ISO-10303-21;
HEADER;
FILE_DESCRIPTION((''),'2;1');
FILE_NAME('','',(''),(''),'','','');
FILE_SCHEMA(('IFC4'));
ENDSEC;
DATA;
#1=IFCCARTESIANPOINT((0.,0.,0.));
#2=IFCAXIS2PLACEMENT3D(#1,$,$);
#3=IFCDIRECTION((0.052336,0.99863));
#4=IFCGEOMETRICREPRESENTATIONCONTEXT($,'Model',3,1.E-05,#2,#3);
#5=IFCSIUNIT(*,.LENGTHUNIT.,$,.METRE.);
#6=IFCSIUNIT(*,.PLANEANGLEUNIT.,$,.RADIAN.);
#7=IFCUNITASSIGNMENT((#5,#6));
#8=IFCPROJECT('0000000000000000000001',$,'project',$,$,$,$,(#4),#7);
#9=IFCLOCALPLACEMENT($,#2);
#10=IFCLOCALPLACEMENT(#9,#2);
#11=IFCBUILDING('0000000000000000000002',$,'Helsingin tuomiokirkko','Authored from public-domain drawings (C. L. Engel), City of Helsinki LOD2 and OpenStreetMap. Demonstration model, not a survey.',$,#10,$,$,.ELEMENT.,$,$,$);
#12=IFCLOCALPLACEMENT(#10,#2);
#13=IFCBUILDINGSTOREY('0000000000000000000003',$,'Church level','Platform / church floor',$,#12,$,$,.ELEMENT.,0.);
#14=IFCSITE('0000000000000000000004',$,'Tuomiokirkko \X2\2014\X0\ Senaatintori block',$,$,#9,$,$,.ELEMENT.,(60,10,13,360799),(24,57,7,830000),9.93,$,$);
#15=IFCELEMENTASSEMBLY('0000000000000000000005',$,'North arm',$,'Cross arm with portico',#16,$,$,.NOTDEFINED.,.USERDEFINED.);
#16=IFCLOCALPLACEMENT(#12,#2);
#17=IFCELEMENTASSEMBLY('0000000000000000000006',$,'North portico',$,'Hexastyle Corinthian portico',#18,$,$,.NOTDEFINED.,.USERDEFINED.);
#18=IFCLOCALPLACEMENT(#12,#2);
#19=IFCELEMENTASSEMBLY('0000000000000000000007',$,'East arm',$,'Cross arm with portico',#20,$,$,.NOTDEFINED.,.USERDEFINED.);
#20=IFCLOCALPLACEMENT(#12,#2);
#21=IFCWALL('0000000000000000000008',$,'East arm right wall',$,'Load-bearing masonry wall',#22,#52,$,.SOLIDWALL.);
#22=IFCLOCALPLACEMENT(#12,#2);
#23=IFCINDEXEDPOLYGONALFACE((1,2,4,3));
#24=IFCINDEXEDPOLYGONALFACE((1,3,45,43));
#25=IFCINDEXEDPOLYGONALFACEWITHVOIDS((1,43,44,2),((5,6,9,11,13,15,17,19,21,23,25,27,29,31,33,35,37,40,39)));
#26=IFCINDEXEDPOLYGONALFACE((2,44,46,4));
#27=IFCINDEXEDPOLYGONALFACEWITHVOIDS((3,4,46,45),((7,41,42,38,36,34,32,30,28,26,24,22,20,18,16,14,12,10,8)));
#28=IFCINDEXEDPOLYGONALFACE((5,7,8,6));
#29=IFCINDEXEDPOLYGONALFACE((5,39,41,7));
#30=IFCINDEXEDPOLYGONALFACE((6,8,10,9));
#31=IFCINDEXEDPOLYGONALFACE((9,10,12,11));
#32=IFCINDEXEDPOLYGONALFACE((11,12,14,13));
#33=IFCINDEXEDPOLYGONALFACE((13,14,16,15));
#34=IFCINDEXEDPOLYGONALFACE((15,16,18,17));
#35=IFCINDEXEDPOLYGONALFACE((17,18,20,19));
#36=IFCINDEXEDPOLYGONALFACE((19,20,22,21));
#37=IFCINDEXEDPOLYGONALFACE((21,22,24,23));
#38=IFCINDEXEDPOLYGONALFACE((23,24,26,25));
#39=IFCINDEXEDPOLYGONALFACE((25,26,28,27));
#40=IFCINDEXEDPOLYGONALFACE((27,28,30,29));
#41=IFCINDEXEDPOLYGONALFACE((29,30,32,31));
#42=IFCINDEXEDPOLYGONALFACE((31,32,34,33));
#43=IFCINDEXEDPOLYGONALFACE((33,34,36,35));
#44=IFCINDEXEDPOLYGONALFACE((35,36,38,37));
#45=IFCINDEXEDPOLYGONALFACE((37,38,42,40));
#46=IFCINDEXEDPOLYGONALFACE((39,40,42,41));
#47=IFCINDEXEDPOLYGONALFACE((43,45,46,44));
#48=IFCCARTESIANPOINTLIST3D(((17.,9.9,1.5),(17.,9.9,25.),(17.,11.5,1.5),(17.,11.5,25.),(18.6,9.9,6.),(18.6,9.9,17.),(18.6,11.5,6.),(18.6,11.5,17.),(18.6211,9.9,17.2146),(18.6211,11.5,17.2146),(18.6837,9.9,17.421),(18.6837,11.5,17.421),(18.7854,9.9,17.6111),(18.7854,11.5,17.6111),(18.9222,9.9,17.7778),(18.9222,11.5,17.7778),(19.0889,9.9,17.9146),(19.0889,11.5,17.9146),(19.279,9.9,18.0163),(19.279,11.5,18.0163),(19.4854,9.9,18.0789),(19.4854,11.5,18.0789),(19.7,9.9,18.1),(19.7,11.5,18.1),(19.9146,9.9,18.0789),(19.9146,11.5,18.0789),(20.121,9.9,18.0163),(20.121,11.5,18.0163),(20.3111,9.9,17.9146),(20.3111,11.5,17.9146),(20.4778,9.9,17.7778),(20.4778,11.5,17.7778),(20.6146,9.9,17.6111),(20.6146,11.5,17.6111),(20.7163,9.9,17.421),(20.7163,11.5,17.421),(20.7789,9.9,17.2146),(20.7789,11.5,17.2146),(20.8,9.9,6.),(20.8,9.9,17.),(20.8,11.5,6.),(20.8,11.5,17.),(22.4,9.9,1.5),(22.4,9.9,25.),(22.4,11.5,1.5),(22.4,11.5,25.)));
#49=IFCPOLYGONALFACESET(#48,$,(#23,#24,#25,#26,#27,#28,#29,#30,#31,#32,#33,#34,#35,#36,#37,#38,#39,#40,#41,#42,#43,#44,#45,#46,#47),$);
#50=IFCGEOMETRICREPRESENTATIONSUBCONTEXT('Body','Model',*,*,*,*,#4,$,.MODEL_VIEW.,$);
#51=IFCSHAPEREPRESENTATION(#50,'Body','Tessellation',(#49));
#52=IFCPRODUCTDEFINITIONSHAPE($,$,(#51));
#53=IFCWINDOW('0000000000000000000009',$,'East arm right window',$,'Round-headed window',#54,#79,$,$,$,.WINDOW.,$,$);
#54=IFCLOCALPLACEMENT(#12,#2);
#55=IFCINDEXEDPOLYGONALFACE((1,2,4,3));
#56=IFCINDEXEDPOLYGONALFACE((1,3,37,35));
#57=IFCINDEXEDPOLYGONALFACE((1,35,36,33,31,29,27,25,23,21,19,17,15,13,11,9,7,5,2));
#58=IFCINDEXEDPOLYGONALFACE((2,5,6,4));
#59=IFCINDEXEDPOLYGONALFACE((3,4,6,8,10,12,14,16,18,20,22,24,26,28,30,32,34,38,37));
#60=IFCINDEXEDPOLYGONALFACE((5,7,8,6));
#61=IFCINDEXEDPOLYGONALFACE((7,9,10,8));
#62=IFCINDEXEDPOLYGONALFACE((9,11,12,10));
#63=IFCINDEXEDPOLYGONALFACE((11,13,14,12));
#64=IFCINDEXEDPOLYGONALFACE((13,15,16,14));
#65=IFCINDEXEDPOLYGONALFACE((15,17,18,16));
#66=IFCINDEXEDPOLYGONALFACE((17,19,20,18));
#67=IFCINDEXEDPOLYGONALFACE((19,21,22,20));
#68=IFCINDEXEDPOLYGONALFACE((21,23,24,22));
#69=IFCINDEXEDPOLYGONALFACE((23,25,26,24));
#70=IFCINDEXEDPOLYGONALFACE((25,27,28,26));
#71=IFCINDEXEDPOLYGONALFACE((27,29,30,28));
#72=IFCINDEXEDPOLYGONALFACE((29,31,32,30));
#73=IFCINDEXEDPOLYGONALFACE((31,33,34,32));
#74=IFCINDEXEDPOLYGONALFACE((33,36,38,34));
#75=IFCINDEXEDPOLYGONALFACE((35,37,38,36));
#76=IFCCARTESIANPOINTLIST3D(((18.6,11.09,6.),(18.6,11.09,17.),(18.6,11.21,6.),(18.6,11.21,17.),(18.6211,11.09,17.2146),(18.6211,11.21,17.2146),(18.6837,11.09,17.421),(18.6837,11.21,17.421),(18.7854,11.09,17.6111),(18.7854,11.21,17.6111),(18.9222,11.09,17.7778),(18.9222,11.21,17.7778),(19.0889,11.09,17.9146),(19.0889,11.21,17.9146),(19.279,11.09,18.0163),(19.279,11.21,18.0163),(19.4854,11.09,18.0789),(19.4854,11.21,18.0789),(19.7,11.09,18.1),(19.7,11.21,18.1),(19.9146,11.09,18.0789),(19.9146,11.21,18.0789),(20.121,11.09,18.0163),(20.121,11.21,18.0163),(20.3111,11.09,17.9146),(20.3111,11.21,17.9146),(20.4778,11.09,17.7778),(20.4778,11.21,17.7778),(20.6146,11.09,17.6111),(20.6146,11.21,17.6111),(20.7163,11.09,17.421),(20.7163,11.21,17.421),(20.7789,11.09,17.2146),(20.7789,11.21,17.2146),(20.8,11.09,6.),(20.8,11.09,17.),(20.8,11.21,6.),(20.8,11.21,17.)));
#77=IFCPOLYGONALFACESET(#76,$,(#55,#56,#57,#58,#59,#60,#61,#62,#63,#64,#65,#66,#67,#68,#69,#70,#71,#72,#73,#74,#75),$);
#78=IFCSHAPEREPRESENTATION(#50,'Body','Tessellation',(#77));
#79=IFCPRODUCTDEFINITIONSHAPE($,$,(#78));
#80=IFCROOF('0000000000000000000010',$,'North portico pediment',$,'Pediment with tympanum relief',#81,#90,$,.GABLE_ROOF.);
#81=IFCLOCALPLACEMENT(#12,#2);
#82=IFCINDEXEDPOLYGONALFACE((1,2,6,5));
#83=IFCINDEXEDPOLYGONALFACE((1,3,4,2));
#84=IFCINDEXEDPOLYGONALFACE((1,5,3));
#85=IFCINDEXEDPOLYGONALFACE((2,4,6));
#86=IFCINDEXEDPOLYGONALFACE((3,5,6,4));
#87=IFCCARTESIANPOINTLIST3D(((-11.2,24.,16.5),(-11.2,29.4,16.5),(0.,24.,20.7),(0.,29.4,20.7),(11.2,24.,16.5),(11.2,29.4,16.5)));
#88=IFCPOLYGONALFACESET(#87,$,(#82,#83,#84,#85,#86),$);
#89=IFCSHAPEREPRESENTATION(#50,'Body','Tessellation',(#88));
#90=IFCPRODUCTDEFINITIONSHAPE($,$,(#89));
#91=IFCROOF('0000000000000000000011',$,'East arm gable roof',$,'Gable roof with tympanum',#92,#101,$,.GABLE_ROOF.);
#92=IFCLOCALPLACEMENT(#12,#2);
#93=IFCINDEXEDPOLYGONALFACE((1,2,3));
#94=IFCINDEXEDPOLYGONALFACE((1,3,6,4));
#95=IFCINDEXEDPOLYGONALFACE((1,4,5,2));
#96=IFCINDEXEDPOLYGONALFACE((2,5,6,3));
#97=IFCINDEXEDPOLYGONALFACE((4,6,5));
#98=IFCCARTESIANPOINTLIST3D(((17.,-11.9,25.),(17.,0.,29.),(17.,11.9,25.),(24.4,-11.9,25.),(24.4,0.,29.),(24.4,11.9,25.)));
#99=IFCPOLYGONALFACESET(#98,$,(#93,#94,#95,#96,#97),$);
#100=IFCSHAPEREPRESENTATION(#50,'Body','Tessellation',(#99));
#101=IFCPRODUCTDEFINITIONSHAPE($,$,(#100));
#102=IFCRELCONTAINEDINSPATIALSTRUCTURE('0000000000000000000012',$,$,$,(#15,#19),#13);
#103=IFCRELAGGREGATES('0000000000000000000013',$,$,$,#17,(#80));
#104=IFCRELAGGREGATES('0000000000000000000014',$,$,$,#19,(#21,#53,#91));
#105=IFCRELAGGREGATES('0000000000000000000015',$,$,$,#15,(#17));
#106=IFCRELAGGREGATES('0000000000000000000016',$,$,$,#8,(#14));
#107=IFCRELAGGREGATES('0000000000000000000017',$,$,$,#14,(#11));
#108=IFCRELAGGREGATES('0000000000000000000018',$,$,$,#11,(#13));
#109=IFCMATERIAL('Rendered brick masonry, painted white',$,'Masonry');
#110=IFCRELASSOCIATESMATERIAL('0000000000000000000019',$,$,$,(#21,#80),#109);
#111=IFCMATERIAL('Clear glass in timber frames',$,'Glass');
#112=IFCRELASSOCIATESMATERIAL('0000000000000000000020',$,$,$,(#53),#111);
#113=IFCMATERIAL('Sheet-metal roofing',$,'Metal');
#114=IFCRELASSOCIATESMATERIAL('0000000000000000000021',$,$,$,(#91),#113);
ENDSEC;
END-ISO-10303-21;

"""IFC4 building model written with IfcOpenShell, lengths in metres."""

from ifc_helpers import new_model, si_unit, direction, frame, origin, origin_2d_with_axis, place, context, subcontext, project, spatial, polyline, rectangle, outline, extrude, material, element, fill, aggregate, save


model = new_model("IFC4")

# Units and contexts
model_context = context("Model", 3, precision=1e-05, world=origin(), true_north=direction((0.052336, 0.99863)))
body_context = subcontext(model_context, "Body", "Model", "MODEL_VIEW")
ifc_project = project(units=[si_unit("LENGTHUNIT", "METRE"), si_unit("PLANEANGLEUNIT", "RADIAN")], contexts=[model_context])

# Site, building, storey
site_placement = place(None, origin())
site = spatial("IfcSite", under=ifc_project, at=site_placement, Name="Tuomiokirkko — Senaatintori block", CompositionType="ELEMENT", RefLatitude=(60, 10, 13, 360799), RefLongitude=(24, 57, 7, 830000), RefElevation=9.93)
building_placement = place(site_placement, origin())
building = spatial("IfcBuilding", under=site, at=building_placement, Name="Helsingin tuomiokirkko", Description="Authored from public-domain drawings (C. L. Engel), City of Helsinki LOD2 and OpenStreetMap. Demonstration model, not a survey.", CompositionType="ELEMENT")
storey_placement = place(building_placement, origin())
storey = spatial("IfcBuildingStorey", under=building, at=storey_placement, Name="Church level", Description="Platform / church floor", CompositionType="ELEMENT", Elevation=0.0)

# Element assemblies
assembly_1_placement = place(building_placement, origin())
assembly_1 = element("IfcElementAssembly", 1, at=assembly_1_placement, inside=storey, Name="North arm", ObjectType="Cross arm with portico", AssemblyPlace="NOTDEFINED", PredefinedType="USERDEFINED")
assembly_2_placement = place(building_placement, origin())
assembly_2 = element("IfcElementAssembly", 2, at=assembly_2_placement, Name="North portico", ObjectType="Hexastyle Corinthian portico", AssemblyPlace="NOTDEFINED", PredefinedType="USERDEFINED")

# Element assembly
assembly_3_placement = place(building_placement, origin())
assembly_3 = element("IfcElementAssembly", 3, at=assembly_3_placement, inside=storey, Name="East arm", ObjectType="Cross arm with portico", AssemblyPlace="NOTDEFINED", PredefinedType="USERDEFINED")
ifc_material_1 = material(Name="Rendered brick masonry, painted white", Category="Masonry")

# Shared definitions
ifc_material_2 = material(Name="Clear glass in timber frames", Category="Glass")

# Wall, opening, window
wall_1_placement = place(building_placement, origin())
wall_1 = element("IfcWall", 4, at=wall_1_placement, material=ifc_material_1, Name="East arm right wall", ObjectType="Load-bearing masonry wall", PredefinedType="SOLIDWALL", context=body_context, shape_type="SweptSolid", body=[
    extrude(rectangle(XDim=5.4, YDim=1.6, at=origin_2d_with_axis()), frame((19.7, 10.7, 1.5)), (0.0, 0.0, 1.0), 23.5),
])
opening_1_placement = place(building_placement, origin())
opening_1 = element("IfcOpeningElement", 5, at=opening_1_placement, cuts=wall_1, PredefinedType="OPENING", context=body_context, shape_type="SweptSolid", body=[
    extrude(outline(polyline([(-1.1, 0.0), (1.1, 0.0), (1.1, 11.0), (1.0789, 11.2146), (1.0163, 11.421), (0.9146, 11.6111), (0.7778, 11.7778), (0.6111, 11.9146), (0.421, 12.0163), (0.2146, 12.0789), (0.0, 12.1), (-0.2146, 12.0789), (-0.421, 12.0163), (-0.6111, 11.9146), (-0.7778, 11.7778), (-0.9146, 11.6111), (-1.0163, 11.421), (-1.0789, 11.2146), (-1.1, 11.0), (-1.1, 0.0)])), frame((19.7, 11.7, 6.0), z_axis=(0.0, -1.0, 0.0), x_axis=(1.0, 0.0, 0.0)), (0.0, 0.0, 1.0), 2.0),
])
window_1_placement = place(building_placement, origin())
window_1 = element("IfcWindow", 6, at=window_1_placement, material=ifc_material_2, Name="East arm right window", ObjectType="Round-headed window", PredefinedType="WINDOW", context=body_context, shape_type="SweptSolid", body=[
    extrude(outline(polyline([(-1.1, 0.0), (1.1, 0.0), (1.1, 11.0), (1.0789, 11.2146), (1.0163, 11.421), (0.9146, 11.6111), (0.7778, 11.7778), (0.6111, 11.9146), (0.421, 12.0163), (0.2146, 12.0789), (0.0, 12.1), (-0.2146, 12.0789), (-0.421, 12.0163), (-0.6111, 11.9146), (-0.7778, 11.7778), (-0.9146, 11.6111), (-1.0163, 11.421), (-1.0789, 11.2146), (-1.1, 11.0), (-1.1, 0.0)])), frame((19.7, 11.21, 6.0), z_axis=(0.0, -1.0, 0.0), x_axis=(1.0, 0.0, 0.0)), (0.0, 0.0, 1.0), 0.12),
])
fill(opening_1, window_1)

# Roofs
roof_1_placement = place(building_placement, origin())
roof_1 = element("IfcRoof", 7, at=roof_1_placement, material=ifc_material_1, Name="North portico pediment", ObjectType="Pediment with tympanum relief", PredefinedType="GABLE_ROOF", context=body_context, shape_type="SweptSolid", body=[
    extrude(outline(polyline([(-11.2, 0.0), (11.2, 0.0), (0.0, 4.2), (-11.2, 0.0)])), frame((0.0, 24.0, 16.5), z_axis=(0.0, 1.0, 0.0), x_axis=(-1.0, 0.0, 0.0)), (0.0, 0.0, 1.0), 5.4),
])
aggregate(assembly_2, [roof_1])
ifc_material_3 = material(Name="Sheet-metal roofing", Category="Metal")
roof_2_placement = place(building_placement, origin())
roof_2 = element("IfcRoof", 8, at=roof_2_placement, material=ifc_material_3, Name="East arm gable roof", ObjectType="Gable roof with tympanum", PredefinedType="GABLE_ROOF", context=body_context, shape_type="SweptSolid", body=[
    extrude(outline(polyline([(-11.9, 0.0), (11.9, 0.0), (0.0, 4.0), (-11.9, 0.0)])), frame((17.0, 0.0, 25.0), z_axis=(1.0, 0.0, 0.0), x_axis=(0.0, 1.0, 0.0)), (0.0, 0.0, 1.0), 7.4),
])
aggregate(assembly_3, [wall_1, window_1, roof_2])

aggregate(assembly_1, [assembly_2])

save(model, "model.ifc")
